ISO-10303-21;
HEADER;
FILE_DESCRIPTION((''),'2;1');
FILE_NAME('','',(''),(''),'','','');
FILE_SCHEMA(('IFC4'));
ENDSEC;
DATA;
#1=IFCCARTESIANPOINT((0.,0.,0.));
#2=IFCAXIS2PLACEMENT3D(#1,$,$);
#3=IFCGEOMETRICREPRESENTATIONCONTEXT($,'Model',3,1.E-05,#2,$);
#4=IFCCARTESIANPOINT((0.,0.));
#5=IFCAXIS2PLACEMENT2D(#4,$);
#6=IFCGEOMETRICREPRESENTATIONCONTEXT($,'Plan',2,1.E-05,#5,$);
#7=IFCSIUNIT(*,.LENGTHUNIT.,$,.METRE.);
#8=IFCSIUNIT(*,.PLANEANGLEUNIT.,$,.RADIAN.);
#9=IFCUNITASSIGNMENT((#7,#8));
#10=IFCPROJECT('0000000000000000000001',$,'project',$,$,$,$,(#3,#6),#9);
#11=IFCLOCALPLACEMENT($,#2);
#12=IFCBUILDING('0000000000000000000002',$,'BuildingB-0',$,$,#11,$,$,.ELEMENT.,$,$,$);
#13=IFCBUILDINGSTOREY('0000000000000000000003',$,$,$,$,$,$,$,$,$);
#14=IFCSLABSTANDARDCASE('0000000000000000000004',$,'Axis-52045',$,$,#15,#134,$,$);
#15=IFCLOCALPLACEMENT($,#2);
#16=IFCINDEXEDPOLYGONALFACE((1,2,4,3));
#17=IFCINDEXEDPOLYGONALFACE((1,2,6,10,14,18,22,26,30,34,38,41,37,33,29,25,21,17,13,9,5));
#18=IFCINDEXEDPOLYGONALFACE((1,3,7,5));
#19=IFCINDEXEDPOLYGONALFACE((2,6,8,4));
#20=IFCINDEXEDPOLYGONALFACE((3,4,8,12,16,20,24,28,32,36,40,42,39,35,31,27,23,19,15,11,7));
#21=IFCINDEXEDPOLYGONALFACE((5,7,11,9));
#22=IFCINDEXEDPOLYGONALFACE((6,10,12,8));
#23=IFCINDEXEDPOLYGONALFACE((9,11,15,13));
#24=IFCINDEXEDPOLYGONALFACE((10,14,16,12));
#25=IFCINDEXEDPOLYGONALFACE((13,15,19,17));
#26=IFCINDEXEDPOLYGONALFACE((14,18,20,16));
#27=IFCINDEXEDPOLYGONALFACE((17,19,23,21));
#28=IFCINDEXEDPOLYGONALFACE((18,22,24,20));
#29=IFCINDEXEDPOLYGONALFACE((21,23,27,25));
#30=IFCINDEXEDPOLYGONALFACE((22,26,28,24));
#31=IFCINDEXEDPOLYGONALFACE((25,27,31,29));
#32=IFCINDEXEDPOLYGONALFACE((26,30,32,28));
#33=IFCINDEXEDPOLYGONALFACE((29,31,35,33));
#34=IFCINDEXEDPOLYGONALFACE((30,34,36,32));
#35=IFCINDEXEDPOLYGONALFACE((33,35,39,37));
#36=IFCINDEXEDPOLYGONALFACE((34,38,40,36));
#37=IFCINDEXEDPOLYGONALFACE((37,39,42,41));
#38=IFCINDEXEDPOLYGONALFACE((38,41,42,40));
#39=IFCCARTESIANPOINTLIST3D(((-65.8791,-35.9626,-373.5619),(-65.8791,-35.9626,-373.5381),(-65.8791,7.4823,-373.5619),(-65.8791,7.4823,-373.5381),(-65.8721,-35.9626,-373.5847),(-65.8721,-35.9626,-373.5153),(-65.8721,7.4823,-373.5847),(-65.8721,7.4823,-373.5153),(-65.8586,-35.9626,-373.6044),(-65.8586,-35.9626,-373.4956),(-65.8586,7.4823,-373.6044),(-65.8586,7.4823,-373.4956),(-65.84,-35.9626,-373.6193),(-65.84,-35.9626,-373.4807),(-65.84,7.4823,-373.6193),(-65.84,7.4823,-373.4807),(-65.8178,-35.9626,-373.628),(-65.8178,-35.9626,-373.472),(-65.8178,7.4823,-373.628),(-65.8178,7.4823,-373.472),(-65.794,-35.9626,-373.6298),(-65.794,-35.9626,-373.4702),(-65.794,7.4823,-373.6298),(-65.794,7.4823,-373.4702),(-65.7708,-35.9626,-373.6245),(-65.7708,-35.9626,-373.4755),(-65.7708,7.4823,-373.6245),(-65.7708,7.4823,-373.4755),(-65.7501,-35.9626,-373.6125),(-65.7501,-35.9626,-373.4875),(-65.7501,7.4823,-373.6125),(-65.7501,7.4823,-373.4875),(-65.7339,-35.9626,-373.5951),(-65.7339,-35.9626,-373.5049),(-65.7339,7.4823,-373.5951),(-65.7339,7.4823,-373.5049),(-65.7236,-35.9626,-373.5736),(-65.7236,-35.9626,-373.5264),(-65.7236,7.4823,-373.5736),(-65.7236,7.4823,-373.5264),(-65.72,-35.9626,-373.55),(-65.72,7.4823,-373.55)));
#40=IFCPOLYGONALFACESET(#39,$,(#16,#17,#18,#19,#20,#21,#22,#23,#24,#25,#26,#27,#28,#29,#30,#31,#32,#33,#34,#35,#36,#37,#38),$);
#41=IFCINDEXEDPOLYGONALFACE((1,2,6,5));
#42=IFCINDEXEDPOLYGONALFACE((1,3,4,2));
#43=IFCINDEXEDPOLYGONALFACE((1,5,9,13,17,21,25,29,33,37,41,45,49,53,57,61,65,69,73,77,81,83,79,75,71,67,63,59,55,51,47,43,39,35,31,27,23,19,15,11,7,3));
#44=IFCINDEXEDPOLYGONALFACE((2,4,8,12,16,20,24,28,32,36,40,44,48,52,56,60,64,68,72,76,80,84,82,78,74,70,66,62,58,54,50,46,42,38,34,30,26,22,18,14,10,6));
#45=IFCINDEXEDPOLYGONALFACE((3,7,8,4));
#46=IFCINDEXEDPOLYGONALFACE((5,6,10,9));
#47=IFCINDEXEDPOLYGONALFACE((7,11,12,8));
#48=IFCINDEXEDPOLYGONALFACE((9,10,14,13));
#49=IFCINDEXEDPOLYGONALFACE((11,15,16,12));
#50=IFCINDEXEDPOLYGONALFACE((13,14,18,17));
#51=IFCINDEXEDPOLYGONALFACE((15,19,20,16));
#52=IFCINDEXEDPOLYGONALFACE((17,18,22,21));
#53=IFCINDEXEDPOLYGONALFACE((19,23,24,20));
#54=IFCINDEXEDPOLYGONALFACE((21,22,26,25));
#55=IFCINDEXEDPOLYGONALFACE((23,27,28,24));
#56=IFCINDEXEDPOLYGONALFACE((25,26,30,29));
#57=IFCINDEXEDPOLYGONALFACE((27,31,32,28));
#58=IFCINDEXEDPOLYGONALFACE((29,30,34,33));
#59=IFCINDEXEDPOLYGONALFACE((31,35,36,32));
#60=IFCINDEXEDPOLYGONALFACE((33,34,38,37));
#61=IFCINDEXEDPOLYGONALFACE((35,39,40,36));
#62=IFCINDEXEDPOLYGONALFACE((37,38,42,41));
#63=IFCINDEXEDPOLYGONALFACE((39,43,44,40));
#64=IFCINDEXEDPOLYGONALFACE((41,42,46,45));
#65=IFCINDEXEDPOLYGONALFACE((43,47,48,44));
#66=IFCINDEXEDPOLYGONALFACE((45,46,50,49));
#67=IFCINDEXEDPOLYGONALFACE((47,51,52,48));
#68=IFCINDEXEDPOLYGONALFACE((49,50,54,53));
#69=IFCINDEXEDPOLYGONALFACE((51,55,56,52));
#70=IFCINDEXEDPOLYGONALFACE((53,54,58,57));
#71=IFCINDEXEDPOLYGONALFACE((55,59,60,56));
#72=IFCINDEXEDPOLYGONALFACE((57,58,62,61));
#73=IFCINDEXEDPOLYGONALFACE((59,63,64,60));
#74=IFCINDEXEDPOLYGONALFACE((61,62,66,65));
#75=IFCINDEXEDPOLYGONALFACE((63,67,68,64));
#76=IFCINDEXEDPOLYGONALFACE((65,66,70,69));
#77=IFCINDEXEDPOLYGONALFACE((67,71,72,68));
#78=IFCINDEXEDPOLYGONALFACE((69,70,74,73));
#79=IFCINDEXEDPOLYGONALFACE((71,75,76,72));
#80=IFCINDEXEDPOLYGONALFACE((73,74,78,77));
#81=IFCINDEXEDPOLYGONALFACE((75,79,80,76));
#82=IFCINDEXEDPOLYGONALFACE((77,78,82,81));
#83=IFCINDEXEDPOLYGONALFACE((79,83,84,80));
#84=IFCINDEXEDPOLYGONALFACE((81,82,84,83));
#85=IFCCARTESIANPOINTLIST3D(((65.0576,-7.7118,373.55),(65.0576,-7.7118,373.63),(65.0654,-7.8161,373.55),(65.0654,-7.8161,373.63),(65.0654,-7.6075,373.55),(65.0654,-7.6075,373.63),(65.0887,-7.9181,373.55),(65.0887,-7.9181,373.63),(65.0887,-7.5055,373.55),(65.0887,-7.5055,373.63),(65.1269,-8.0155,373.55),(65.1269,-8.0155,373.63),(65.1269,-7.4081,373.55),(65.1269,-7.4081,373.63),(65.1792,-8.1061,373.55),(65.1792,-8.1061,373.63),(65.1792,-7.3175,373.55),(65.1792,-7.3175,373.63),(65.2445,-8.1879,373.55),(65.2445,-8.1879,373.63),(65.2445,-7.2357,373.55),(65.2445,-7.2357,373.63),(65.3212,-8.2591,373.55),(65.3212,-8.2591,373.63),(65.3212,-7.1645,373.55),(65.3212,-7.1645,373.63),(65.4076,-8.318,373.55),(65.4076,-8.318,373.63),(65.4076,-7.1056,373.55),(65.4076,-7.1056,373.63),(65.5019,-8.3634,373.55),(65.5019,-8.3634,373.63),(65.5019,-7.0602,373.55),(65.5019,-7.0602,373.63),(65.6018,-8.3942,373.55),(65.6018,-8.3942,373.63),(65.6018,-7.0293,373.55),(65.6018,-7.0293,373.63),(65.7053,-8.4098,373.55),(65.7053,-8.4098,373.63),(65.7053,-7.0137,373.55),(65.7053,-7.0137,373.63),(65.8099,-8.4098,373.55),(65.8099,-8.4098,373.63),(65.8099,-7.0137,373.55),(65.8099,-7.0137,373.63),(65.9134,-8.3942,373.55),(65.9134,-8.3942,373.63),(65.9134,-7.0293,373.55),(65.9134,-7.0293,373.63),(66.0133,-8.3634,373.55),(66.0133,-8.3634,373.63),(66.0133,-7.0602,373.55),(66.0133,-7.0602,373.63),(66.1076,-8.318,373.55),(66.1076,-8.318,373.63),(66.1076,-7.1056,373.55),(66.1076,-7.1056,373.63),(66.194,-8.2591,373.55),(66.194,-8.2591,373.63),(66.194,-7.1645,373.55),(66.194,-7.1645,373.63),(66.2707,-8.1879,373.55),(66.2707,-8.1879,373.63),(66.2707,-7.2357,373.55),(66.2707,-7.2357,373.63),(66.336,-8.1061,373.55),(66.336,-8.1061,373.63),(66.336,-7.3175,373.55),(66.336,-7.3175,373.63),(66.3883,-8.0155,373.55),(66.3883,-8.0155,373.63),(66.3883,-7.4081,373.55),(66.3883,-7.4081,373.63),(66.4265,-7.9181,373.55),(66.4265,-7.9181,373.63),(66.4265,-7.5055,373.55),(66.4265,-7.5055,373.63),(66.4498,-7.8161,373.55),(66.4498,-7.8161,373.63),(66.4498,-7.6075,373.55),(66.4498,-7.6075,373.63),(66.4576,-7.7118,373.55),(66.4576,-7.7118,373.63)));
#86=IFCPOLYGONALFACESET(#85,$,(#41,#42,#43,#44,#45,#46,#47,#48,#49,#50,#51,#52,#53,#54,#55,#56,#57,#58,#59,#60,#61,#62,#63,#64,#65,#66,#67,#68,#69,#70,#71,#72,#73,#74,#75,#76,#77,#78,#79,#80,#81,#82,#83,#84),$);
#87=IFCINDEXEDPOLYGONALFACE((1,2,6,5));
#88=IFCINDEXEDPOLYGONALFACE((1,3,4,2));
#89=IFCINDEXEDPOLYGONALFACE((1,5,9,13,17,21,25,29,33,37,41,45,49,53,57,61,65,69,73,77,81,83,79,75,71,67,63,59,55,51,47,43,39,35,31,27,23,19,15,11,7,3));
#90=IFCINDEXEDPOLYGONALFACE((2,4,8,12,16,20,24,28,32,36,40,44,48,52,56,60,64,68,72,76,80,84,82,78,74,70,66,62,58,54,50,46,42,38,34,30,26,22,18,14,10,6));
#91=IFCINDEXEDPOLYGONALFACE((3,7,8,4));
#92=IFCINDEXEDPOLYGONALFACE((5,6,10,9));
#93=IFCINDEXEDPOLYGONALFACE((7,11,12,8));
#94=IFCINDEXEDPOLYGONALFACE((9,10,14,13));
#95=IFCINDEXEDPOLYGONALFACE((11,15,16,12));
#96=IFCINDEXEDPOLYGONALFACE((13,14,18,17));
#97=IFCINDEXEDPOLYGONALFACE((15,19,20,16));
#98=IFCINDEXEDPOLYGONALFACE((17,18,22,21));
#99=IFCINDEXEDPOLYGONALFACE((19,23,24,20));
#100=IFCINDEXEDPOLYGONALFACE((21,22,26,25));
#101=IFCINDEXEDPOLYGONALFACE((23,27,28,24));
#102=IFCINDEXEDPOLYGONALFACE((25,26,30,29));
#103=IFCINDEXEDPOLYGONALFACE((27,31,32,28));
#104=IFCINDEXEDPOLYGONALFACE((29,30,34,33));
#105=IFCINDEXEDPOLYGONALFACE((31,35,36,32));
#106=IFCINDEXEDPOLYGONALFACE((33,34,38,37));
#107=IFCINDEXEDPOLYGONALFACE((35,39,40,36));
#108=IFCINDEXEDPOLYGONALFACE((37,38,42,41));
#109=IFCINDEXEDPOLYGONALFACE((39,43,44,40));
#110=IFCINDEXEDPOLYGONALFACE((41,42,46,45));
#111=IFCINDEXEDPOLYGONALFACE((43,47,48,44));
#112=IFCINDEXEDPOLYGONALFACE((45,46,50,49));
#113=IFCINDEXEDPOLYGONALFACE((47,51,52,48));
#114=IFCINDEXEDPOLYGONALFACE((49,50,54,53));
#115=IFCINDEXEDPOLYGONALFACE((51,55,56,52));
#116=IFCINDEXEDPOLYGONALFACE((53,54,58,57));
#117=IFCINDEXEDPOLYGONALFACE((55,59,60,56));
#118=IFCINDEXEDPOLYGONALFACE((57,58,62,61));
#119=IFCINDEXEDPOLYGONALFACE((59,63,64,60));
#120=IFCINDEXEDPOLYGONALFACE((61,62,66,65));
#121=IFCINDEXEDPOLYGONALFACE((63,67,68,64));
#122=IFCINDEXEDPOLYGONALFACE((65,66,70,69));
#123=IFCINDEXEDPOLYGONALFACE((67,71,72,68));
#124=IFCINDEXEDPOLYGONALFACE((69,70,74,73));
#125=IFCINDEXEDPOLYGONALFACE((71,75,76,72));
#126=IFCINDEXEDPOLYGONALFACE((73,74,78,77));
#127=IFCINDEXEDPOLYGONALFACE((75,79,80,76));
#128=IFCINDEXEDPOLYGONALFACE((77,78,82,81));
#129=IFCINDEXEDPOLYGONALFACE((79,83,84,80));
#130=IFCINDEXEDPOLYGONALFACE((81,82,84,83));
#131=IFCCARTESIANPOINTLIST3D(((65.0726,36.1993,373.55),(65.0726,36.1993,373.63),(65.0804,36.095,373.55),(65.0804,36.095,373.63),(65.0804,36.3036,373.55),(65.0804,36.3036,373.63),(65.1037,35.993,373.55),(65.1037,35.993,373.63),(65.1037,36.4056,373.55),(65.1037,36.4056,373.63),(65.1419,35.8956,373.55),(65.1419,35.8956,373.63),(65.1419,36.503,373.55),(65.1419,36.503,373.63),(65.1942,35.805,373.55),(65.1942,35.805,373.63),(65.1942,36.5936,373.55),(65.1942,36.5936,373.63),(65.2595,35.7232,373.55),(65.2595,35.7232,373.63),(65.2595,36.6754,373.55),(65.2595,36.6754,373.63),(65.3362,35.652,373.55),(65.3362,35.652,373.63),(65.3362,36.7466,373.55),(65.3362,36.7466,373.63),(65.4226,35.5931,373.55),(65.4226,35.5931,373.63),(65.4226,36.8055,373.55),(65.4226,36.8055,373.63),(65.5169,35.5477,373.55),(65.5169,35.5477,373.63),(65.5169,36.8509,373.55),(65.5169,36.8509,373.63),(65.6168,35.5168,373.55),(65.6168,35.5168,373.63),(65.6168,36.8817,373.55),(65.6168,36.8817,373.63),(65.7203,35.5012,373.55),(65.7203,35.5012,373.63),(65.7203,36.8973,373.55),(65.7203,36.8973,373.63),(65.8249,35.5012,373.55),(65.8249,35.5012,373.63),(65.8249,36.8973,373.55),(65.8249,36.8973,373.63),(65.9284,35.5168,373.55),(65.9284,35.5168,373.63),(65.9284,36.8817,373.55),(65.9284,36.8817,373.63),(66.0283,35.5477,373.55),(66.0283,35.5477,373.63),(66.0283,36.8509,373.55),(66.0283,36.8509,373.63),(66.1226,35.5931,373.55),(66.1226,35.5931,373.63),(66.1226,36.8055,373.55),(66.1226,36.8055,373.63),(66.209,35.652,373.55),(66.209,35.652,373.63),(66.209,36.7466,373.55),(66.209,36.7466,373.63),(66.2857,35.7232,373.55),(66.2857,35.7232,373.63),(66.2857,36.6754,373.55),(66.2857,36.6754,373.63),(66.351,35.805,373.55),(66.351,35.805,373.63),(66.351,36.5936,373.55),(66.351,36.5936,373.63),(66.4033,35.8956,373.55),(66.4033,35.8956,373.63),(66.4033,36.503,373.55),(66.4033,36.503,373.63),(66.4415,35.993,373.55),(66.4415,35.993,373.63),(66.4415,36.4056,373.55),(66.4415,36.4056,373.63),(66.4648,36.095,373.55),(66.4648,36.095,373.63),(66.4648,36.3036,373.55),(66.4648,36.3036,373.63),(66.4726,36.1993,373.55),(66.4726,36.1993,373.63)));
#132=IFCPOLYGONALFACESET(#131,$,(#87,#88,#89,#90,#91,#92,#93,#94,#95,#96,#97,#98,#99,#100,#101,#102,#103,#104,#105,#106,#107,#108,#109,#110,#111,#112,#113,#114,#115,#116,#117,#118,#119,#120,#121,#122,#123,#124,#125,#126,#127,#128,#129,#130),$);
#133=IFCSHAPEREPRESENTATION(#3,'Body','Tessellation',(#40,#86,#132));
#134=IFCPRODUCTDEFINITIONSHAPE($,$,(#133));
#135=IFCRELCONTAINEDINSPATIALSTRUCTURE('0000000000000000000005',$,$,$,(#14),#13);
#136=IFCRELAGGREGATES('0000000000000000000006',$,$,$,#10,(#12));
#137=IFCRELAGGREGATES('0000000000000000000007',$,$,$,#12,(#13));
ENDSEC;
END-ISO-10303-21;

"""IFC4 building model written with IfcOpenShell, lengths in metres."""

from ifc_helpers import new_model, entity, si_unit, frame, origin, origin_2d, place, context, project, spatial, circle, extrude, element, save


model = new_model("IFC4")

# Units and contexts
model_context = context("Model", 3, precision=1e-05, world=origin())
plan_context = context("Plan", 2, precision=1e-05, world=origin_2d())
ifc_project = project(units=[si_unit("LENGTHUNIT", "METRE"), si_unit("PLANEANGLEUNIT", "RADIAN")], contexts=[model_context, plan_context])

# Building, storey
building_placement = place(None, origin())
building = spatial("IfcBuilding", under=ifc_project, at=building_placement, Name="BuildingB-0", CompositionType="ELEMENT")
storey = spatial("IfcBuildingStorey", under=building)

# Slab
element("IfcSlabStandardCase", 1, inside=storey, Name="Axis-52045", context=model_context, shape_type="AdvancedSweptSolid", body=[
    entity("IfcSurfaceCurveSweptAreaSolid", entity("IfcCircleProfileDef", "AREA", None, None, 0.08), None, entity("IfcPolyline", [entity("IfcCartesianPoint", [65.8, -7.4823, 373.55]), entity("IfcCartesianPoint", [65.8, 35.9626, 373.55])]), None, None, entity("IfcPlane", entity("IfcAxis2Placement3D", entity("IfcCartesianPoint", [65.8, -7.4823, 373.55]), entity("IfcDirection", [0.0, 0.0, 1.0]), entity("IfcDirection", [1.0, 0.0, 0.0])))),
    extrude(circle(Radius=0.7), frame((65.7576, -7.7118, 373.55)), (0.0, 0.0, 1.0), 0.08),
    extrude(circle(Radius=0.7), frame((65.7726, 36.1993, 373.55)), (0.0, 0.0, 1.0), 0.08),
])

save(model, "model.ifc")
